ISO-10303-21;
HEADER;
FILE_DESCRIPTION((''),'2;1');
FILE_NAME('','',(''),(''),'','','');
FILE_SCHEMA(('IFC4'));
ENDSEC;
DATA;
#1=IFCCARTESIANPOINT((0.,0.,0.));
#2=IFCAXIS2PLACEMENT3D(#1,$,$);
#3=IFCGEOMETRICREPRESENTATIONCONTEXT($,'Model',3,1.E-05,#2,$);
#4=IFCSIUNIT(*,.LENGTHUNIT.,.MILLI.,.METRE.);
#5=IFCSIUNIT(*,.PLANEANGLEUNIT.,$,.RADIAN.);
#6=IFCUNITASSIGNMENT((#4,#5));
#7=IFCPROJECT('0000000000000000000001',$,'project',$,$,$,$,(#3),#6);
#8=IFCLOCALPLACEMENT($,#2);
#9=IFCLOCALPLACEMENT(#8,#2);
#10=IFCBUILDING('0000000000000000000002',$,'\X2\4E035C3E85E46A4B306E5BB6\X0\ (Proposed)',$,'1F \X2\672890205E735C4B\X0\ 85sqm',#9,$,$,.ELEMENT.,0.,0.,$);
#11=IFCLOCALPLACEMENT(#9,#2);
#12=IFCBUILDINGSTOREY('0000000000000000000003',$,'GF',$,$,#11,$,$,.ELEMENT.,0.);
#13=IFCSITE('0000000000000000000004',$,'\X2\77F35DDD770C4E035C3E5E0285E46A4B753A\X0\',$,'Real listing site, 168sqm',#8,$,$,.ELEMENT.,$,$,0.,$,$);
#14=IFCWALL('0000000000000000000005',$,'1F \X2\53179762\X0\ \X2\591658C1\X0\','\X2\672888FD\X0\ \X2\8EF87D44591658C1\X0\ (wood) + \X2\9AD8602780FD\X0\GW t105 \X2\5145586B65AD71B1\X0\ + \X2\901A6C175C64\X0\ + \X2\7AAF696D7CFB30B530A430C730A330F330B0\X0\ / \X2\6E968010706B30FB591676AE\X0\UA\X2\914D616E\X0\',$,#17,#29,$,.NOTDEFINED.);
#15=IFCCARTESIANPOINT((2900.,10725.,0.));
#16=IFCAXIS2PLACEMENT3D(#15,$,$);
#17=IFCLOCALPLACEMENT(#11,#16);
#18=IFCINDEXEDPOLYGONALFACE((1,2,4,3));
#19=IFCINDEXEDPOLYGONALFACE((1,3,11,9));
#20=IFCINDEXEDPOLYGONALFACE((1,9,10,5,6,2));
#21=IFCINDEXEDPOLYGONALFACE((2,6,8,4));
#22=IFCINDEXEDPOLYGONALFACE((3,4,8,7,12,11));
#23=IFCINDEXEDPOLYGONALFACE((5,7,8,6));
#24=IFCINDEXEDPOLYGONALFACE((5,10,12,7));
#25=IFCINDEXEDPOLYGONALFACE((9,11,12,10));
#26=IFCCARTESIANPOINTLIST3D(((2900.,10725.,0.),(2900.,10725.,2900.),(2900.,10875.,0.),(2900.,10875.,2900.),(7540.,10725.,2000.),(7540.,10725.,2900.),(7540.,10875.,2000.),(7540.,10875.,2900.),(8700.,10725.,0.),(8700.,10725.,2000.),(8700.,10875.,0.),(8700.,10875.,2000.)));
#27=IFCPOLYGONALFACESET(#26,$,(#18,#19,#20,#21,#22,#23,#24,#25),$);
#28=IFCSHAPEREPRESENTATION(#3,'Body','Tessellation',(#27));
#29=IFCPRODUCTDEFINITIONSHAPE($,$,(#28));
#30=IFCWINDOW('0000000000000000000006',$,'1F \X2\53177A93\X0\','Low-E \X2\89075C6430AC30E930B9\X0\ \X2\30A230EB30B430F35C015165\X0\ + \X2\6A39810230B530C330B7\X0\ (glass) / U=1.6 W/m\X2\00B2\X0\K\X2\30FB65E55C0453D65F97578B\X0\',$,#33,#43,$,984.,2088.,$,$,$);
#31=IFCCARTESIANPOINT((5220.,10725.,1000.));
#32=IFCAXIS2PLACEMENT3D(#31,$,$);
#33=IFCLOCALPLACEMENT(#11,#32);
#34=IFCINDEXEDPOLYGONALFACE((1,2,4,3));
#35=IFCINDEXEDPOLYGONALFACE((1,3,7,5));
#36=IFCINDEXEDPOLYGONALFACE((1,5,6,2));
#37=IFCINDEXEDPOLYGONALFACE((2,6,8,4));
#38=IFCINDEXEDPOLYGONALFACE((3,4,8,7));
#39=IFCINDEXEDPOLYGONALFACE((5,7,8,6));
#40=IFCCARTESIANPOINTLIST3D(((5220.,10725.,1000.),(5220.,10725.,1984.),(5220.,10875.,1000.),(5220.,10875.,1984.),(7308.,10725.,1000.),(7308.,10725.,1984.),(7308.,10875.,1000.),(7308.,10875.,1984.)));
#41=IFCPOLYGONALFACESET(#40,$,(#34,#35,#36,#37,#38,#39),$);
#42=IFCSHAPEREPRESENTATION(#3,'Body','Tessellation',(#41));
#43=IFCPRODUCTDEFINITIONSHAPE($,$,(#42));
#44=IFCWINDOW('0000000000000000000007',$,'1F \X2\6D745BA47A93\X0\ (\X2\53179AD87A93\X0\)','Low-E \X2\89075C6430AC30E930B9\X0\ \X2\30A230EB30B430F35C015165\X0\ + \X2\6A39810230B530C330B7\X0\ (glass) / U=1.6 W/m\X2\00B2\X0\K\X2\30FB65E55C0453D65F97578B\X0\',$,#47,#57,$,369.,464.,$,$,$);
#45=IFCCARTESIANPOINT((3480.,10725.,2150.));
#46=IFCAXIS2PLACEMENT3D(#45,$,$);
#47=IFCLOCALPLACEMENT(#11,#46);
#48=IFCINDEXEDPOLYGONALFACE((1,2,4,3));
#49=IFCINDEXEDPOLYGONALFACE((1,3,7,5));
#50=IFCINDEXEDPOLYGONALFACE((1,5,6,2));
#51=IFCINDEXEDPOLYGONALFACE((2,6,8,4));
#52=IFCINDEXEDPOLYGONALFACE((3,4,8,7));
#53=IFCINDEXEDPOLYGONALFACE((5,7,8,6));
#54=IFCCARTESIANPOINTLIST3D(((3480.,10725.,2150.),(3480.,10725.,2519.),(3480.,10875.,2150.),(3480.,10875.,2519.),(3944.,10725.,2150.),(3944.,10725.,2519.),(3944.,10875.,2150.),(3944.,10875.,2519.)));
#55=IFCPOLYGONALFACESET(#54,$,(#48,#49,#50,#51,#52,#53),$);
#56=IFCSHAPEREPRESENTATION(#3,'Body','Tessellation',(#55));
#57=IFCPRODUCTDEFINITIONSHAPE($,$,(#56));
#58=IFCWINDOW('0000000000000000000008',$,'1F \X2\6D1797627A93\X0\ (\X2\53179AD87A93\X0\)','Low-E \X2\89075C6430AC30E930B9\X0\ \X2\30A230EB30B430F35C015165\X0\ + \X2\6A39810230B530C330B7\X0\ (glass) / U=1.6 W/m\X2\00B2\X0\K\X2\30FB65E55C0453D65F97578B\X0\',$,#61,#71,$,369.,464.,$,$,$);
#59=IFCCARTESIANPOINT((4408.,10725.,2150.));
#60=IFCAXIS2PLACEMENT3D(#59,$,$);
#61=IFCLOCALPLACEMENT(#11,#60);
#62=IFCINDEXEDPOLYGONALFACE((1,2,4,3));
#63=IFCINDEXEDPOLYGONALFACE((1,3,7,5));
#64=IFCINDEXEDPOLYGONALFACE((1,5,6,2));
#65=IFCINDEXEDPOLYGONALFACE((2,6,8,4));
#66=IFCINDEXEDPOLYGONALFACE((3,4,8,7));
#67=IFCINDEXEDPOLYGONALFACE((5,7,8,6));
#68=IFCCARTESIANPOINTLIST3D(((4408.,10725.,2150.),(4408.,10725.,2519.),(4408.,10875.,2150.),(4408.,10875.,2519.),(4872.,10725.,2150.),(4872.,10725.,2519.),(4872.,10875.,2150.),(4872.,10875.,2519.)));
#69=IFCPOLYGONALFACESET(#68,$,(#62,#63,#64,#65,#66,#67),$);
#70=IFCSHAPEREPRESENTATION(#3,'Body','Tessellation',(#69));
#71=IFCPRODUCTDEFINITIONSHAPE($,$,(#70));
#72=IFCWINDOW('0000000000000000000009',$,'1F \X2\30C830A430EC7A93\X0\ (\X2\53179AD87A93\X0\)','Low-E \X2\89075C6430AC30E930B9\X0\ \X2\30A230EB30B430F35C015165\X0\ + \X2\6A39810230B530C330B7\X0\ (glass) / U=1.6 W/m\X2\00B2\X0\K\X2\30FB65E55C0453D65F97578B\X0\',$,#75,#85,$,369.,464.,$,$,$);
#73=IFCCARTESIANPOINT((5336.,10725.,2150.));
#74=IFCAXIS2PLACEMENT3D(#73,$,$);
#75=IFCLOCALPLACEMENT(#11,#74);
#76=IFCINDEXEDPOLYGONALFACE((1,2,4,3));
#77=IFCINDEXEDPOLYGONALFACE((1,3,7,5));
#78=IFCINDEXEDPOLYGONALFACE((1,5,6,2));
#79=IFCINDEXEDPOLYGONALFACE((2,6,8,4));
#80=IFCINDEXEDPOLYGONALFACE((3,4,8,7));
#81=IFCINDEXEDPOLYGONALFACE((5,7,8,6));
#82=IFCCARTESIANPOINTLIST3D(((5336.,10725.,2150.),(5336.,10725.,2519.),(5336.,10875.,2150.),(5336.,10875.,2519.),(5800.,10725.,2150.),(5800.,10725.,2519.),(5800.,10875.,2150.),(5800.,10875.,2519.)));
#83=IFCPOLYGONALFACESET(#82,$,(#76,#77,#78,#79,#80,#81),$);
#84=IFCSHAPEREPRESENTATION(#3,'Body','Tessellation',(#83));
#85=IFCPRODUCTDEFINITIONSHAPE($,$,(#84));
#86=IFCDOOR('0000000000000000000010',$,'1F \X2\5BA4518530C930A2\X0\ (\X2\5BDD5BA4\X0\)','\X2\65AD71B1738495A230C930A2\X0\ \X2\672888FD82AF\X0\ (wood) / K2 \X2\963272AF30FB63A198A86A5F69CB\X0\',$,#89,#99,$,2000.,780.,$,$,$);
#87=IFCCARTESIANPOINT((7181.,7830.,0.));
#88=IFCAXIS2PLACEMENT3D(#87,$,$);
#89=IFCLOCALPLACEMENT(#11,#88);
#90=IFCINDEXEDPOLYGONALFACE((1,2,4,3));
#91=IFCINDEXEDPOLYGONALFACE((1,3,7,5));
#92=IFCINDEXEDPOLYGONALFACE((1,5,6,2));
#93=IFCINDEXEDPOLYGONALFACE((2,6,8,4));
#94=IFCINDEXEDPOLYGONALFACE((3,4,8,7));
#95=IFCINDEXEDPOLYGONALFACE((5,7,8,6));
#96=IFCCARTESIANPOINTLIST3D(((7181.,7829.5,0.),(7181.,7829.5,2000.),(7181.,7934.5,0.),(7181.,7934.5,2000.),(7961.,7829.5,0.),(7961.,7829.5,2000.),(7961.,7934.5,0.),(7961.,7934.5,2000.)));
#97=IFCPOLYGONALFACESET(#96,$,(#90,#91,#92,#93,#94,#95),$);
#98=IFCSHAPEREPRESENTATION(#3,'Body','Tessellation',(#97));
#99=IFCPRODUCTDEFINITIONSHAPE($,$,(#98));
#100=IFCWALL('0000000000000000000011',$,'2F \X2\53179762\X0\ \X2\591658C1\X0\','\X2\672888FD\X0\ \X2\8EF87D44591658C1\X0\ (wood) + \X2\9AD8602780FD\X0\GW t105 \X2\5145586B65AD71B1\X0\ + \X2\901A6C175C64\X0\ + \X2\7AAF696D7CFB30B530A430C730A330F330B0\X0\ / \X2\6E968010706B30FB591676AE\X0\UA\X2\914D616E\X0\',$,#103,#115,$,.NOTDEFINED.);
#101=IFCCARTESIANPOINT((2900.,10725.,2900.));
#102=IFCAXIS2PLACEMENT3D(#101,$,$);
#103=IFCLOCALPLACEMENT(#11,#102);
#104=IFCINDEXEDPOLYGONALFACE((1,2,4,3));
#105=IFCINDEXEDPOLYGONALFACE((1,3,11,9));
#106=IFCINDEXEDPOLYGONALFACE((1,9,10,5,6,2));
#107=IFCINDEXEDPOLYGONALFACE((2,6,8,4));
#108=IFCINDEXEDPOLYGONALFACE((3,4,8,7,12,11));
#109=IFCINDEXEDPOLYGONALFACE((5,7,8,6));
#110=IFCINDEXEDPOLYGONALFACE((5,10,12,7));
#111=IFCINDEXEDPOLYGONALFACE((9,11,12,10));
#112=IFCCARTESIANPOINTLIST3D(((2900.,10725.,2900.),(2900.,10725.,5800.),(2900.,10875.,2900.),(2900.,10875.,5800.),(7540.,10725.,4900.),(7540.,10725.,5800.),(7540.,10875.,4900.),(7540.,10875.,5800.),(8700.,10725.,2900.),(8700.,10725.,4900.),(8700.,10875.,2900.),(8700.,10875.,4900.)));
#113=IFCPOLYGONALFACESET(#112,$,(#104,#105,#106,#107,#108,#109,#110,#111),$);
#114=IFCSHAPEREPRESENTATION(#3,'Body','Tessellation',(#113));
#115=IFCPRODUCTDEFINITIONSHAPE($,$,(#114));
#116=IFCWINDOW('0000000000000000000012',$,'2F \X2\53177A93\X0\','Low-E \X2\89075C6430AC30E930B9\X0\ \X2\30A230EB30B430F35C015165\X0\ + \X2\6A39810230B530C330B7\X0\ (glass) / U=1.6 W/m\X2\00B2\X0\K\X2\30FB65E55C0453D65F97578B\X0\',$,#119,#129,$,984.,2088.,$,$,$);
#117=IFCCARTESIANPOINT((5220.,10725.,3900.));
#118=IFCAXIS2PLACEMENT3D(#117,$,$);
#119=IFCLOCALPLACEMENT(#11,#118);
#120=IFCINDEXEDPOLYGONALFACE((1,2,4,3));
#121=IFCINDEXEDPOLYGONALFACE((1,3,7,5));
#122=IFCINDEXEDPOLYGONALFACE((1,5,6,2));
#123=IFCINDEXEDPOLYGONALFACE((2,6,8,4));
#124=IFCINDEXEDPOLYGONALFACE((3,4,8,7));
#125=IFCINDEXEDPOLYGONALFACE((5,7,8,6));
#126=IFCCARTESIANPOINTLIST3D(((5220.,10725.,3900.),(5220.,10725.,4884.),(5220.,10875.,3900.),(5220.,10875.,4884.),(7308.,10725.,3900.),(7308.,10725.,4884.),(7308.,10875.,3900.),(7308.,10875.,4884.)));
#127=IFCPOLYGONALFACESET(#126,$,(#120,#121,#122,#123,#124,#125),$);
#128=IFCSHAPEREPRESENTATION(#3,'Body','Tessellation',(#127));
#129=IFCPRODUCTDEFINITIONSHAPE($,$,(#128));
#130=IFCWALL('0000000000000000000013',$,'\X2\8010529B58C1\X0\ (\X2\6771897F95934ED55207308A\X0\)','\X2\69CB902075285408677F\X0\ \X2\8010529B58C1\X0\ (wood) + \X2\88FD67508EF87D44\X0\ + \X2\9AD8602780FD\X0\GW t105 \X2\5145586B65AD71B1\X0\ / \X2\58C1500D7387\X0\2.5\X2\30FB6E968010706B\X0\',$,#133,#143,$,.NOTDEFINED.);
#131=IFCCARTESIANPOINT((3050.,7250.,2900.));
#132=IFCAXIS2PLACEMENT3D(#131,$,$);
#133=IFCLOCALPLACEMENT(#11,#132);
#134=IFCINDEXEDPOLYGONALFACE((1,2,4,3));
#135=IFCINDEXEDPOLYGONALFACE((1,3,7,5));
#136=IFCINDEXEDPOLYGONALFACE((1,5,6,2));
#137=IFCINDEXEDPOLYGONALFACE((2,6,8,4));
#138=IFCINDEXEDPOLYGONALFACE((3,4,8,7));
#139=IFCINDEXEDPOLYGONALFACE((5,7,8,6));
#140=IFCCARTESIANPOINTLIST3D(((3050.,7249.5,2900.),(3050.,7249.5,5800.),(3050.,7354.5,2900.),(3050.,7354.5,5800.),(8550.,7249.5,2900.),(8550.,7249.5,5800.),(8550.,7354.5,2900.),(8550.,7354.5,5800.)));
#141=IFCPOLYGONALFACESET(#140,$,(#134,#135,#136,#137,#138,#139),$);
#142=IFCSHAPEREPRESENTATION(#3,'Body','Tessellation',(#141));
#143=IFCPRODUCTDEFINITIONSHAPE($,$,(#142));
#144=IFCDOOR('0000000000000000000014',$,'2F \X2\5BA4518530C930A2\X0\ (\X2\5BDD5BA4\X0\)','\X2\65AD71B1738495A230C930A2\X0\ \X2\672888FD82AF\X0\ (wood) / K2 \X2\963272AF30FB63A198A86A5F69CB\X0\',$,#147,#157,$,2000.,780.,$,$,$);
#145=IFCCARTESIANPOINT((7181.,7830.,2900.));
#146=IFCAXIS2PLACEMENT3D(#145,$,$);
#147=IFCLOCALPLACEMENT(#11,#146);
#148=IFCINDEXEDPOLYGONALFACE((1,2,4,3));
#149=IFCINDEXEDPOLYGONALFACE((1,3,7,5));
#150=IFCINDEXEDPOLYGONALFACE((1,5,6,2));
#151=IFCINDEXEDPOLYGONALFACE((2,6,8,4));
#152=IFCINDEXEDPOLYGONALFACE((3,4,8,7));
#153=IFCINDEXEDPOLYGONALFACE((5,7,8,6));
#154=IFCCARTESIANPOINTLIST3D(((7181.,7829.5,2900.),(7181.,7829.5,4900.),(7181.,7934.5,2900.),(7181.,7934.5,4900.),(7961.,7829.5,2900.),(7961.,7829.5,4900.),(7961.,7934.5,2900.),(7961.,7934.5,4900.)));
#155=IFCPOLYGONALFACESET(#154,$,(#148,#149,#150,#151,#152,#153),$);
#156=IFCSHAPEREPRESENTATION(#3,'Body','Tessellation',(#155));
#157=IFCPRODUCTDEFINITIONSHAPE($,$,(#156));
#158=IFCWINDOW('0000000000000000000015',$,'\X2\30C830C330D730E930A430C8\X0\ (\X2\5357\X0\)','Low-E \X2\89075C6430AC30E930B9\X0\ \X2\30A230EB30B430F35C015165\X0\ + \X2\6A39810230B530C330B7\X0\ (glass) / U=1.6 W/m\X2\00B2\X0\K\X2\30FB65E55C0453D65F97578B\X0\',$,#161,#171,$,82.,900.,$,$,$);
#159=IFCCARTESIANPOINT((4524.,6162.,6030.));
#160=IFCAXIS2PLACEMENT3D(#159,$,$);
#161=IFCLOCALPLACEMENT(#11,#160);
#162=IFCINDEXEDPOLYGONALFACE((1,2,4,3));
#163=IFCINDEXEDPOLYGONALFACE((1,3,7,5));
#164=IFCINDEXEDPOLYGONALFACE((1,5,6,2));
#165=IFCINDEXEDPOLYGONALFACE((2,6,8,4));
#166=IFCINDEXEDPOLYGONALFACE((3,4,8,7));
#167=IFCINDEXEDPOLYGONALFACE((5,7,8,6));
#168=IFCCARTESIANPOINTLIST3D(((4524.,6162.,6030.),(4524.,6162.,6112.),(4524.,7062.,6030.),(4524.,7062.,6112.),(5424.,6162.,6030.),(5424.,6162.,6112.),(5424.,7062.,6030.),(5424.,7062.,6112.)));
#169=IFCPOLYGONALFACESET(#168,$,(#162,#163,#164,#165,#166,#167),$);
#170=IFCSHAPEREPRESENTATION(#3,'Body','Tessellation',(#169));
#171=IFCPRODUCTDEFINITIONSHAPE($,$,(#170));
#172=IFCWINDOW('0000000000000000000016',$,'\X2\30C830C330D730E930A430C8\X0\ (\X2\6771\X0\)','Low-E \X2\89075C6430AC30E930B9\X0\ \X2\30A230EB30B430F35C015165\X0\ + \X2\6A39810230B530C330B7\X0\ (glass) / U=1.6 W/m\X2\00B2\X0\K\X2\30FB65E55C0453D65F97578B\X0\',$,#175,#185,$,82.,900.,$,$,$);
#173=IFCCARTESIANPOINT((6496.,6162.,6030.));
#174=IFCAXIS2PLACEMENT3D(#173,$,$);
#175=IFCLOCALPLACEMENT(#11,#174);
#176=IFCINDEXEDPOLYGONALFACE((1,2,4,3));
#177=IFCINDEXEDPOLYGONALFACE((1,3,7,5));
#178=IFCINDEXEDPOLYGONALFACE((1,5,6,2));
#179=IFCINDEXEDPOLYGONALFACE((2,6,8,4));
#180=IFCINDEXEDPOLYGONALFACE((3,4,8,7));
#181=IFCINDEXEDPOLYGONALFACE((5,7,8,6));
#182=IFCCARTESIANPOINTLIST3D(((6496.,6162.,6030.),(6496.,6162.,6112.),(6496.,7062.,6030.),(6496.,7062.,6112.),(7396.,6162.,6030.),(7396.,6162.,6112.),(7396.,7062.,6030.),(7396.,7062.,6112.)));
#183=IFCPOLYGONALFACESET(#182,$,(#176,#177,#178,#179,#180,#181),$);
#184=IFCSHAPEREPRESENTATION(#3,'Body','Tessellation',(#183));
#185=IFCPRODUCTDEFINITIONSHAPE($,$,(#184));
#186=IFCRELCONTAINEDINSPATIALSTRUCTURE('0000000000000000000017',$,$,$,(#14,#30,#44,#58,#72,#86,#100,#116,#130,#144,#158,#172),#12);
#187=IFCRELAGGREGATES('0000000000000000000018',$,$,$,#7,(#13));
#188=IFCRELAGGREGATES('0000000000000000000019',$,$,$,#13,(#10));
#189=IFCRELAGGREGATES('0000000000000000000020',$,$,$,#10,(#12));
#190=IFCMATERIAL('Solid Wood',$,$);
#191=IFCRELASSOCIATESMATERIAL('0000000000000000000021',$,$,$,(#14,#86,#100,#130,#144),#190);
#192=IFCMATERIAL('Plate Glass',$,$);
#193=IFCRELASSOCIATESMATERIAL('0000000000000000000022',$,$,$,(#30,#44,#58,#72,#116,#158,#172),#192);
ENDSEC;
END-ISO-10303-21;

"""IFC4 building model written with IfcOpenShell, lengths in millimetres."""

from ifc_helpers import new_model, si_unit, frame, frame_2d, origin, place, context, project, spatial, rectangle, extrude, material, element, fill, save


model = new_model("IFC4")

# Units and contexts
model_context = context("Model", 3, precision=1e-05, world=origin())
ifc_project = project(units=[si_unit("LENGTHUNIT", "METRE", prefix="MILLI"), si_unit("PLANEANGLEUNIT", "RADIAN")], contexts=[model_context])

# Site, building, storey
site_placement = place(None, origin())
site = spatial("IfcSite", under=ifc_project, at=site_placement, Name="石川県七尾市藤橋町", ObjectType="Real listing site, 168sqm", CompositionType="ELEMENT", RefElevation=0.0)
building_placement = place(site_placement, origin())
building = spatial("IfcBuilding", under=site, at=building_placement, Name="七尾藤橋の家 (Proposed)", ObjectType="1F 木造平屋 85sqm", CompositionType="ELEMENT", ElevationOfRefHeight=0.0, ElevationOfTerrain=0.0)
storey_placement = place(building_placement, origin())
storey = spatial("IfcBuildingStorey", under=building, at=storey_placement, Name="GF", CompositionType="ELEMENT", Elevation=0.0)

# Wall, openings, windows
ifc_material_1 = material(Name="Solid Wood")
wall_1_placement = place(storey_placement, frame((2900.0, 10725.0, 0.0)))
wall_1 = element("IfcWall", 1, at=wall_1_placement, inside=storey, material=ifc_material_1, Name="1F 北面 外壁", Description="木製 軸組外壁 (wood) + 高性能GW t105 充填断熱 + 通気層 + 窯業系サイディング / 準耐火・外皮UA配慮", PredefinedType="NOTDEFINED", context=model_context, shape_type="SweptSolid", body=[
    extrude(rectangle(XDim=5800.0, YDim=150.0, at=frame_2d((2900.0, 75.0))), frame((2900.0, 10725.0, 0.0)), (0.0, 0.0, 1.0), 2900.0),
])
opening_1_placement = place(storey_placement, frame((5220.0, 10725.0, 1000.0)))
opening_1 = element("IfcOpeningElement", 2, at=opening_1_placement, cuts=wall_1, PredefinedType="NOTDEFINED", context=model_context, shape_type="SweptSolid", body=[
    extrude(rectangle(XDim=2088.0, YDim=150.0, at=frame_2d((1044.0, 75.0))), frame((5220.0, 10725.0, 1000.0)), (0.0, 0.0, 1.0), 984.0),
])
opening_2_placement = place(storey_placement, frame((3480.0, 10725.0, 2150.0)))
opening_2 = element("IfcOpeningElement", 3, at=opening_2_placement, cuts=wall_1, PredefinedType="NOTDEFINED", context=model_context, shape_type="SweptSolid", body=[
    extrude(rectangle(XDim=464.0, YDim=150.0, at=frame_2d((232.0, 75.0))), frame((3480.0, 10725.0, 2150.0)), (0.0, 0.0, 1.0), 369.0),
])
opening_3_placement = place(storey_placement, frame((4408.0, 10725.0, 2150.0)))
opening_3 = element("IfcOpeningElement", 4, at=opening_3_placement, cuts=wall_1, PredefinedType="NOTDEFINED", context=model_context, shape_type="SweptSolid", body=[
    extrude(rectangle(XDim=464.0, YDim=150.0, at=frame_2d((232.0, 75.0))), frame((4408.0, 10725.0, 2150.0)), (0.0, 0.0, 1.0), 369.0),
])
opening_4_placement = place(storey_placement, frame((5336.0, 10725.0, 2150.0)))
opening_4 = element("IfcOpeningElement", 5, at=opening_4_placement, cuts=wall_1, PredefinedType="NOTDEFINED", context=model_context, shape_type="SweptSolid", body=[
    extrude(rectangle(XDim=464.0, YDim=150.0, at=frame_2d((232.0, 75.0))), frame((5336.0, 10725.0, 2150.0)), (0.0, 0.0, 1.0), 369.0),
])
ifc_material_2 = material(Name="Plate Glass")
window_1_placement = place(storey_placement, frame((5220.0, 10725.0, 1000.0)))
window_1 = element("IfcWindow", 6, at=window_1_placement, inside=storey, material=ifc_material_2, Name="1F 北窓", Description="Low-E 複層ガラス アルゴン封入 + 樹脂サッシ (glass) / U=1.6 W/m²K・日射取得型", OverallHeight=984.0, OverallWidth=2088.0, context=model_context, shape_type="SweptSolid", body=[
    extrude(rectangle(XDim=2088.0, YDim=150.0, at=frame_2d((1044.0, 75.0))), frame((5220.0, 10725.0, 1000.0)), (0.0, 0.0, 1.0), 984.0),
])
fill(opening_1, window_1)
window_2_placement = place(storey_placement, frame((3480.0, 10725.0, 2150.0)))
window_2 = element("IfcWindow", 7, at=window_2_placement, inside=storey, material=ifc_material_2, Name="1F 浴室窓 (北高窓)", Description="Low-E 複層ガラス アルゴン封入 + 樹脂サッシ (glass) / U=1.6 W/m²K・日射取得型", OverallHeight=369.0, OverallWidth=464.0, context=model_context, shape_type="SweptSolid", body=[
    extrude(rectangle(XDim=464.0, YDim=150.0, at=frame_2d((232.0, 75.0))), frame((3480.0, 10725.0, 2150.0)), (0.0, 0.0, 1.0), 369.0),
])
fill(opening_2, window_2)
window_3_placement = place(storey_placement, frame((4408.0, 10725.0, 2150.0)))
window_3 = element("IfcWindow", 8, at=window_3_placement, inside=storey, material=ifc_material_2, Name="1F 洗面窓 (北高窓)", Description="Low-E 複層ガラス アルゴン封入 + 樹脂サッシ (glass) / U=1.6 W/m²K・日射取得型", OverallHeight=369.0, OverallWidth=464.0, context=model_context, shape_type="SweptSolid", body=[
    extrude(rectangle(XDim=464.0, YDim=150.0, at=frame_2d((232.0, 75.0))), frame((4408.0, 10725.0, 2150.0)), (0.0, 0.0, 1.0), 369.0),
])
fill(opening_3, window_3)
window_4_placement = place(storey_placement, frame((5336.0, 10725.0, 2150.0)))
window_4 = element("IfcWindow", 9, at=window_4_placement, inside=storey, material=ifc_material_2, Name="1F トイレ窓 (北高窓)", Description="Low-E 複層ガラス アルゴン封入 + 樹脂サッシ (glass) / U=1.6 W/m²K・日射取得型", OverallHeight=369.0, OverallWidth=464.0, context=model_context, shape_type="SweptSolid", body=[
    extrude(rectangle(XDim=464.0, YDim=150.0, at=frame_2d((232.0, 75.0))), frame((5336.0, 10725.0, 2150.0)), (0.0, 0.0, 1.0), 369.0),
])
fill(opening_4, window_4)

# Door
door_1_placement = place(storey_placement, frame((7181.0, 7830.0, 0.0)))
element("IfcDoor", 10, at=door_1_placement, inside=storey, material=ifc_material_1, Name="1F 室内ドア (寝室)", Description="断熱玄関ドア 木製芯 (wood) / K2 防犯・採風機構", OverallHeight=2000.0, OverallWidth=780.0, context=model_context, shape_type="SweptSolid", body=[
    extrude(rectangle(XDim=780.0, YDim=105.0, at=frame_2d((390.0, 52.0))), frame((7181.0, 7830.0, 0.0)), (0.0, 0.0, 1.0), 2000.0),
])

# Wall, opening, window
wall_2_placement = place(storey_placement, frame((2900.0, 10725.0, 2900.0)))
wall_2 = element("IfcWall", 11, at=wall_2_placement, inside=storey, material=ifc_material_1, Name="2F 北面 外壁", Description="木製 軸組外壁 (wood) + 高性能GW t105 充填断熱 + 通気層 + 窯業系サイディング / 準耐火・外皮UA配慮", PredefinedType="NOTDEFINED", context=model_context, shape_type="SweptSolid", body=[
    extrude(rectangle(XDim=5800.0, YDim=150.0, at=frame_2d((2900.0, 75.0))), frame((2900.0, 10725.0, 2900.0)), (0.0, 0.0, 1.0), 2900.0),
])
opening_5_placement = place(storey_placement, frame((5220.0, 10725.0, 3900.0)))
opening_5 = element("IfcOpeningElement", 12, at=opening_5_placement, cuts=wall_2, PredefinedType="NOTDEFINED", context=model_context, shape_type="SweptSolid", body=[
    extrude(rectangle(XDim=2088.0, YDim=150.0, at=frame_2d((1044.0, 75.0))), frame((5220.0, 10725.0, 3900.0)), (0.0, 0.0, 1.0), 984.0),
])
window_5_placement = place(storey_placement, frame((5220.0, 10725.0, 3900.0)))
window_5 = element("IfcWindow", 13, at=window_5_placement, inside=storey, material=ifc_material_2, Name="2F 北窓", Description="Low-E 複層ガラス アルゴン封入 + 樹脂サッシ (glass) / U=1.6 W/m²K・日射取得型", OverallHeight=984.0, OverallWidth=2088.0, context=model_context, shape_type="SweptSolid", body=[
    extrude(rectangle(XDim=2088.0, YDim=150.0, at=frame_2d((1044.0, 75.0))), frame((5220.0, 10725.0, 3900.0)), (0.0, 0.0, 1.0), 984.0),
])
fill(opening_5, window_5)

# Wall
wall_3_placement = place(storey_placement, frame((3050.0, 7250.0, 2900.0)))
element("IfcWall", 14, at=wall_3_placement, inside=storey, material=ifc_material_1, Name="耐力壁 (東西間仕切り)", Description="構造用合板 耐力壁 (wood) + 製材軸組 + 高性能GW t105 充填断熱 / 壁倍率2.5・準耐火", PredefinedType="NOTDEFINED", context=model_context, shape_type="SweptSolid", body=[
    extrude(rectangle(XDim=5500.0, YDim=105.0, at=frame_2d((2750.0, 52.0))), frame((3050.0, 7250.0, 2900.0)), (0.0, 0.0, 1.0), 2900.0),
])

# Door
door_2_placement = place(storey_placement, frame((7181.0, 7830.0, 2900.0)))
element("IfcDoor", 15, at=door_2_placement, inside=storey, material=ifc_material_1, Name="2F 室内ドア (寝室)", Description="断熱玄関ドア 木製芯 (wood) / K2 防犯・採風機構", OverallHeight=2000.0, OverallWidth=780.0, context=model_context, shape_type="SweptSolid", body=[
    extrude(rectangle(XDim=780.0, YDim=105.0, at=frame_2d((390.0, 52.0))), frame((7181.0, 7830.0, 2900.0)), (0.0, 0.0, 1.0), 2000.0),
])

# Windows
window_6_placement = place(storey_placement, frame((4524.0, 6162.0, 6030.0)))
element("IfcWindow", 16, at=window_6_placement, inside=storey, material=ifc_material_2, Name="トップライト (南)", Description="Low-E 複層ガラス アルゴン封入 + 樹脂サッシ (glass) / U=1.6 W/m²K・日射取得型", OverallHeight=82.0, OverallWidth=900.0, context=model_context, shape_type="SweptSolid", body=[
    extrude(rectangle(XDim=900.0, YDim=900.0, at=frame_2d((450.0, 450.0))), frame((4524.0, 6162.0, 6030.0)), (0.0, 0.0, 1.0), 82.0),
])
window_7_placement = place(storey_placement, frame((6496.0, 6162.0, 6030.0)))
element("IfcWindow", 17, at=window_7_placement, inside=storey, material=ifc_material_2, Name="トップライト (東)", Description="Low-E 複層ガラス アルゴン封入 + 樹脂サッシ (glass) / U=1.6 W/m²K・日射取得型", OverallHeight=82.0, OverallWidth=900.0, context=model_context, shape_type="SweptSolid", body=[
    extrude(rectangle(XDim=900.0, YDim=900.0, at=frame_2d((450.0, 450.0))), frame((6496.0, 6162.0, 6030.0)), (0.0, 0.0, 1.0), 82.0),
])

save(model, "model.ifc")
